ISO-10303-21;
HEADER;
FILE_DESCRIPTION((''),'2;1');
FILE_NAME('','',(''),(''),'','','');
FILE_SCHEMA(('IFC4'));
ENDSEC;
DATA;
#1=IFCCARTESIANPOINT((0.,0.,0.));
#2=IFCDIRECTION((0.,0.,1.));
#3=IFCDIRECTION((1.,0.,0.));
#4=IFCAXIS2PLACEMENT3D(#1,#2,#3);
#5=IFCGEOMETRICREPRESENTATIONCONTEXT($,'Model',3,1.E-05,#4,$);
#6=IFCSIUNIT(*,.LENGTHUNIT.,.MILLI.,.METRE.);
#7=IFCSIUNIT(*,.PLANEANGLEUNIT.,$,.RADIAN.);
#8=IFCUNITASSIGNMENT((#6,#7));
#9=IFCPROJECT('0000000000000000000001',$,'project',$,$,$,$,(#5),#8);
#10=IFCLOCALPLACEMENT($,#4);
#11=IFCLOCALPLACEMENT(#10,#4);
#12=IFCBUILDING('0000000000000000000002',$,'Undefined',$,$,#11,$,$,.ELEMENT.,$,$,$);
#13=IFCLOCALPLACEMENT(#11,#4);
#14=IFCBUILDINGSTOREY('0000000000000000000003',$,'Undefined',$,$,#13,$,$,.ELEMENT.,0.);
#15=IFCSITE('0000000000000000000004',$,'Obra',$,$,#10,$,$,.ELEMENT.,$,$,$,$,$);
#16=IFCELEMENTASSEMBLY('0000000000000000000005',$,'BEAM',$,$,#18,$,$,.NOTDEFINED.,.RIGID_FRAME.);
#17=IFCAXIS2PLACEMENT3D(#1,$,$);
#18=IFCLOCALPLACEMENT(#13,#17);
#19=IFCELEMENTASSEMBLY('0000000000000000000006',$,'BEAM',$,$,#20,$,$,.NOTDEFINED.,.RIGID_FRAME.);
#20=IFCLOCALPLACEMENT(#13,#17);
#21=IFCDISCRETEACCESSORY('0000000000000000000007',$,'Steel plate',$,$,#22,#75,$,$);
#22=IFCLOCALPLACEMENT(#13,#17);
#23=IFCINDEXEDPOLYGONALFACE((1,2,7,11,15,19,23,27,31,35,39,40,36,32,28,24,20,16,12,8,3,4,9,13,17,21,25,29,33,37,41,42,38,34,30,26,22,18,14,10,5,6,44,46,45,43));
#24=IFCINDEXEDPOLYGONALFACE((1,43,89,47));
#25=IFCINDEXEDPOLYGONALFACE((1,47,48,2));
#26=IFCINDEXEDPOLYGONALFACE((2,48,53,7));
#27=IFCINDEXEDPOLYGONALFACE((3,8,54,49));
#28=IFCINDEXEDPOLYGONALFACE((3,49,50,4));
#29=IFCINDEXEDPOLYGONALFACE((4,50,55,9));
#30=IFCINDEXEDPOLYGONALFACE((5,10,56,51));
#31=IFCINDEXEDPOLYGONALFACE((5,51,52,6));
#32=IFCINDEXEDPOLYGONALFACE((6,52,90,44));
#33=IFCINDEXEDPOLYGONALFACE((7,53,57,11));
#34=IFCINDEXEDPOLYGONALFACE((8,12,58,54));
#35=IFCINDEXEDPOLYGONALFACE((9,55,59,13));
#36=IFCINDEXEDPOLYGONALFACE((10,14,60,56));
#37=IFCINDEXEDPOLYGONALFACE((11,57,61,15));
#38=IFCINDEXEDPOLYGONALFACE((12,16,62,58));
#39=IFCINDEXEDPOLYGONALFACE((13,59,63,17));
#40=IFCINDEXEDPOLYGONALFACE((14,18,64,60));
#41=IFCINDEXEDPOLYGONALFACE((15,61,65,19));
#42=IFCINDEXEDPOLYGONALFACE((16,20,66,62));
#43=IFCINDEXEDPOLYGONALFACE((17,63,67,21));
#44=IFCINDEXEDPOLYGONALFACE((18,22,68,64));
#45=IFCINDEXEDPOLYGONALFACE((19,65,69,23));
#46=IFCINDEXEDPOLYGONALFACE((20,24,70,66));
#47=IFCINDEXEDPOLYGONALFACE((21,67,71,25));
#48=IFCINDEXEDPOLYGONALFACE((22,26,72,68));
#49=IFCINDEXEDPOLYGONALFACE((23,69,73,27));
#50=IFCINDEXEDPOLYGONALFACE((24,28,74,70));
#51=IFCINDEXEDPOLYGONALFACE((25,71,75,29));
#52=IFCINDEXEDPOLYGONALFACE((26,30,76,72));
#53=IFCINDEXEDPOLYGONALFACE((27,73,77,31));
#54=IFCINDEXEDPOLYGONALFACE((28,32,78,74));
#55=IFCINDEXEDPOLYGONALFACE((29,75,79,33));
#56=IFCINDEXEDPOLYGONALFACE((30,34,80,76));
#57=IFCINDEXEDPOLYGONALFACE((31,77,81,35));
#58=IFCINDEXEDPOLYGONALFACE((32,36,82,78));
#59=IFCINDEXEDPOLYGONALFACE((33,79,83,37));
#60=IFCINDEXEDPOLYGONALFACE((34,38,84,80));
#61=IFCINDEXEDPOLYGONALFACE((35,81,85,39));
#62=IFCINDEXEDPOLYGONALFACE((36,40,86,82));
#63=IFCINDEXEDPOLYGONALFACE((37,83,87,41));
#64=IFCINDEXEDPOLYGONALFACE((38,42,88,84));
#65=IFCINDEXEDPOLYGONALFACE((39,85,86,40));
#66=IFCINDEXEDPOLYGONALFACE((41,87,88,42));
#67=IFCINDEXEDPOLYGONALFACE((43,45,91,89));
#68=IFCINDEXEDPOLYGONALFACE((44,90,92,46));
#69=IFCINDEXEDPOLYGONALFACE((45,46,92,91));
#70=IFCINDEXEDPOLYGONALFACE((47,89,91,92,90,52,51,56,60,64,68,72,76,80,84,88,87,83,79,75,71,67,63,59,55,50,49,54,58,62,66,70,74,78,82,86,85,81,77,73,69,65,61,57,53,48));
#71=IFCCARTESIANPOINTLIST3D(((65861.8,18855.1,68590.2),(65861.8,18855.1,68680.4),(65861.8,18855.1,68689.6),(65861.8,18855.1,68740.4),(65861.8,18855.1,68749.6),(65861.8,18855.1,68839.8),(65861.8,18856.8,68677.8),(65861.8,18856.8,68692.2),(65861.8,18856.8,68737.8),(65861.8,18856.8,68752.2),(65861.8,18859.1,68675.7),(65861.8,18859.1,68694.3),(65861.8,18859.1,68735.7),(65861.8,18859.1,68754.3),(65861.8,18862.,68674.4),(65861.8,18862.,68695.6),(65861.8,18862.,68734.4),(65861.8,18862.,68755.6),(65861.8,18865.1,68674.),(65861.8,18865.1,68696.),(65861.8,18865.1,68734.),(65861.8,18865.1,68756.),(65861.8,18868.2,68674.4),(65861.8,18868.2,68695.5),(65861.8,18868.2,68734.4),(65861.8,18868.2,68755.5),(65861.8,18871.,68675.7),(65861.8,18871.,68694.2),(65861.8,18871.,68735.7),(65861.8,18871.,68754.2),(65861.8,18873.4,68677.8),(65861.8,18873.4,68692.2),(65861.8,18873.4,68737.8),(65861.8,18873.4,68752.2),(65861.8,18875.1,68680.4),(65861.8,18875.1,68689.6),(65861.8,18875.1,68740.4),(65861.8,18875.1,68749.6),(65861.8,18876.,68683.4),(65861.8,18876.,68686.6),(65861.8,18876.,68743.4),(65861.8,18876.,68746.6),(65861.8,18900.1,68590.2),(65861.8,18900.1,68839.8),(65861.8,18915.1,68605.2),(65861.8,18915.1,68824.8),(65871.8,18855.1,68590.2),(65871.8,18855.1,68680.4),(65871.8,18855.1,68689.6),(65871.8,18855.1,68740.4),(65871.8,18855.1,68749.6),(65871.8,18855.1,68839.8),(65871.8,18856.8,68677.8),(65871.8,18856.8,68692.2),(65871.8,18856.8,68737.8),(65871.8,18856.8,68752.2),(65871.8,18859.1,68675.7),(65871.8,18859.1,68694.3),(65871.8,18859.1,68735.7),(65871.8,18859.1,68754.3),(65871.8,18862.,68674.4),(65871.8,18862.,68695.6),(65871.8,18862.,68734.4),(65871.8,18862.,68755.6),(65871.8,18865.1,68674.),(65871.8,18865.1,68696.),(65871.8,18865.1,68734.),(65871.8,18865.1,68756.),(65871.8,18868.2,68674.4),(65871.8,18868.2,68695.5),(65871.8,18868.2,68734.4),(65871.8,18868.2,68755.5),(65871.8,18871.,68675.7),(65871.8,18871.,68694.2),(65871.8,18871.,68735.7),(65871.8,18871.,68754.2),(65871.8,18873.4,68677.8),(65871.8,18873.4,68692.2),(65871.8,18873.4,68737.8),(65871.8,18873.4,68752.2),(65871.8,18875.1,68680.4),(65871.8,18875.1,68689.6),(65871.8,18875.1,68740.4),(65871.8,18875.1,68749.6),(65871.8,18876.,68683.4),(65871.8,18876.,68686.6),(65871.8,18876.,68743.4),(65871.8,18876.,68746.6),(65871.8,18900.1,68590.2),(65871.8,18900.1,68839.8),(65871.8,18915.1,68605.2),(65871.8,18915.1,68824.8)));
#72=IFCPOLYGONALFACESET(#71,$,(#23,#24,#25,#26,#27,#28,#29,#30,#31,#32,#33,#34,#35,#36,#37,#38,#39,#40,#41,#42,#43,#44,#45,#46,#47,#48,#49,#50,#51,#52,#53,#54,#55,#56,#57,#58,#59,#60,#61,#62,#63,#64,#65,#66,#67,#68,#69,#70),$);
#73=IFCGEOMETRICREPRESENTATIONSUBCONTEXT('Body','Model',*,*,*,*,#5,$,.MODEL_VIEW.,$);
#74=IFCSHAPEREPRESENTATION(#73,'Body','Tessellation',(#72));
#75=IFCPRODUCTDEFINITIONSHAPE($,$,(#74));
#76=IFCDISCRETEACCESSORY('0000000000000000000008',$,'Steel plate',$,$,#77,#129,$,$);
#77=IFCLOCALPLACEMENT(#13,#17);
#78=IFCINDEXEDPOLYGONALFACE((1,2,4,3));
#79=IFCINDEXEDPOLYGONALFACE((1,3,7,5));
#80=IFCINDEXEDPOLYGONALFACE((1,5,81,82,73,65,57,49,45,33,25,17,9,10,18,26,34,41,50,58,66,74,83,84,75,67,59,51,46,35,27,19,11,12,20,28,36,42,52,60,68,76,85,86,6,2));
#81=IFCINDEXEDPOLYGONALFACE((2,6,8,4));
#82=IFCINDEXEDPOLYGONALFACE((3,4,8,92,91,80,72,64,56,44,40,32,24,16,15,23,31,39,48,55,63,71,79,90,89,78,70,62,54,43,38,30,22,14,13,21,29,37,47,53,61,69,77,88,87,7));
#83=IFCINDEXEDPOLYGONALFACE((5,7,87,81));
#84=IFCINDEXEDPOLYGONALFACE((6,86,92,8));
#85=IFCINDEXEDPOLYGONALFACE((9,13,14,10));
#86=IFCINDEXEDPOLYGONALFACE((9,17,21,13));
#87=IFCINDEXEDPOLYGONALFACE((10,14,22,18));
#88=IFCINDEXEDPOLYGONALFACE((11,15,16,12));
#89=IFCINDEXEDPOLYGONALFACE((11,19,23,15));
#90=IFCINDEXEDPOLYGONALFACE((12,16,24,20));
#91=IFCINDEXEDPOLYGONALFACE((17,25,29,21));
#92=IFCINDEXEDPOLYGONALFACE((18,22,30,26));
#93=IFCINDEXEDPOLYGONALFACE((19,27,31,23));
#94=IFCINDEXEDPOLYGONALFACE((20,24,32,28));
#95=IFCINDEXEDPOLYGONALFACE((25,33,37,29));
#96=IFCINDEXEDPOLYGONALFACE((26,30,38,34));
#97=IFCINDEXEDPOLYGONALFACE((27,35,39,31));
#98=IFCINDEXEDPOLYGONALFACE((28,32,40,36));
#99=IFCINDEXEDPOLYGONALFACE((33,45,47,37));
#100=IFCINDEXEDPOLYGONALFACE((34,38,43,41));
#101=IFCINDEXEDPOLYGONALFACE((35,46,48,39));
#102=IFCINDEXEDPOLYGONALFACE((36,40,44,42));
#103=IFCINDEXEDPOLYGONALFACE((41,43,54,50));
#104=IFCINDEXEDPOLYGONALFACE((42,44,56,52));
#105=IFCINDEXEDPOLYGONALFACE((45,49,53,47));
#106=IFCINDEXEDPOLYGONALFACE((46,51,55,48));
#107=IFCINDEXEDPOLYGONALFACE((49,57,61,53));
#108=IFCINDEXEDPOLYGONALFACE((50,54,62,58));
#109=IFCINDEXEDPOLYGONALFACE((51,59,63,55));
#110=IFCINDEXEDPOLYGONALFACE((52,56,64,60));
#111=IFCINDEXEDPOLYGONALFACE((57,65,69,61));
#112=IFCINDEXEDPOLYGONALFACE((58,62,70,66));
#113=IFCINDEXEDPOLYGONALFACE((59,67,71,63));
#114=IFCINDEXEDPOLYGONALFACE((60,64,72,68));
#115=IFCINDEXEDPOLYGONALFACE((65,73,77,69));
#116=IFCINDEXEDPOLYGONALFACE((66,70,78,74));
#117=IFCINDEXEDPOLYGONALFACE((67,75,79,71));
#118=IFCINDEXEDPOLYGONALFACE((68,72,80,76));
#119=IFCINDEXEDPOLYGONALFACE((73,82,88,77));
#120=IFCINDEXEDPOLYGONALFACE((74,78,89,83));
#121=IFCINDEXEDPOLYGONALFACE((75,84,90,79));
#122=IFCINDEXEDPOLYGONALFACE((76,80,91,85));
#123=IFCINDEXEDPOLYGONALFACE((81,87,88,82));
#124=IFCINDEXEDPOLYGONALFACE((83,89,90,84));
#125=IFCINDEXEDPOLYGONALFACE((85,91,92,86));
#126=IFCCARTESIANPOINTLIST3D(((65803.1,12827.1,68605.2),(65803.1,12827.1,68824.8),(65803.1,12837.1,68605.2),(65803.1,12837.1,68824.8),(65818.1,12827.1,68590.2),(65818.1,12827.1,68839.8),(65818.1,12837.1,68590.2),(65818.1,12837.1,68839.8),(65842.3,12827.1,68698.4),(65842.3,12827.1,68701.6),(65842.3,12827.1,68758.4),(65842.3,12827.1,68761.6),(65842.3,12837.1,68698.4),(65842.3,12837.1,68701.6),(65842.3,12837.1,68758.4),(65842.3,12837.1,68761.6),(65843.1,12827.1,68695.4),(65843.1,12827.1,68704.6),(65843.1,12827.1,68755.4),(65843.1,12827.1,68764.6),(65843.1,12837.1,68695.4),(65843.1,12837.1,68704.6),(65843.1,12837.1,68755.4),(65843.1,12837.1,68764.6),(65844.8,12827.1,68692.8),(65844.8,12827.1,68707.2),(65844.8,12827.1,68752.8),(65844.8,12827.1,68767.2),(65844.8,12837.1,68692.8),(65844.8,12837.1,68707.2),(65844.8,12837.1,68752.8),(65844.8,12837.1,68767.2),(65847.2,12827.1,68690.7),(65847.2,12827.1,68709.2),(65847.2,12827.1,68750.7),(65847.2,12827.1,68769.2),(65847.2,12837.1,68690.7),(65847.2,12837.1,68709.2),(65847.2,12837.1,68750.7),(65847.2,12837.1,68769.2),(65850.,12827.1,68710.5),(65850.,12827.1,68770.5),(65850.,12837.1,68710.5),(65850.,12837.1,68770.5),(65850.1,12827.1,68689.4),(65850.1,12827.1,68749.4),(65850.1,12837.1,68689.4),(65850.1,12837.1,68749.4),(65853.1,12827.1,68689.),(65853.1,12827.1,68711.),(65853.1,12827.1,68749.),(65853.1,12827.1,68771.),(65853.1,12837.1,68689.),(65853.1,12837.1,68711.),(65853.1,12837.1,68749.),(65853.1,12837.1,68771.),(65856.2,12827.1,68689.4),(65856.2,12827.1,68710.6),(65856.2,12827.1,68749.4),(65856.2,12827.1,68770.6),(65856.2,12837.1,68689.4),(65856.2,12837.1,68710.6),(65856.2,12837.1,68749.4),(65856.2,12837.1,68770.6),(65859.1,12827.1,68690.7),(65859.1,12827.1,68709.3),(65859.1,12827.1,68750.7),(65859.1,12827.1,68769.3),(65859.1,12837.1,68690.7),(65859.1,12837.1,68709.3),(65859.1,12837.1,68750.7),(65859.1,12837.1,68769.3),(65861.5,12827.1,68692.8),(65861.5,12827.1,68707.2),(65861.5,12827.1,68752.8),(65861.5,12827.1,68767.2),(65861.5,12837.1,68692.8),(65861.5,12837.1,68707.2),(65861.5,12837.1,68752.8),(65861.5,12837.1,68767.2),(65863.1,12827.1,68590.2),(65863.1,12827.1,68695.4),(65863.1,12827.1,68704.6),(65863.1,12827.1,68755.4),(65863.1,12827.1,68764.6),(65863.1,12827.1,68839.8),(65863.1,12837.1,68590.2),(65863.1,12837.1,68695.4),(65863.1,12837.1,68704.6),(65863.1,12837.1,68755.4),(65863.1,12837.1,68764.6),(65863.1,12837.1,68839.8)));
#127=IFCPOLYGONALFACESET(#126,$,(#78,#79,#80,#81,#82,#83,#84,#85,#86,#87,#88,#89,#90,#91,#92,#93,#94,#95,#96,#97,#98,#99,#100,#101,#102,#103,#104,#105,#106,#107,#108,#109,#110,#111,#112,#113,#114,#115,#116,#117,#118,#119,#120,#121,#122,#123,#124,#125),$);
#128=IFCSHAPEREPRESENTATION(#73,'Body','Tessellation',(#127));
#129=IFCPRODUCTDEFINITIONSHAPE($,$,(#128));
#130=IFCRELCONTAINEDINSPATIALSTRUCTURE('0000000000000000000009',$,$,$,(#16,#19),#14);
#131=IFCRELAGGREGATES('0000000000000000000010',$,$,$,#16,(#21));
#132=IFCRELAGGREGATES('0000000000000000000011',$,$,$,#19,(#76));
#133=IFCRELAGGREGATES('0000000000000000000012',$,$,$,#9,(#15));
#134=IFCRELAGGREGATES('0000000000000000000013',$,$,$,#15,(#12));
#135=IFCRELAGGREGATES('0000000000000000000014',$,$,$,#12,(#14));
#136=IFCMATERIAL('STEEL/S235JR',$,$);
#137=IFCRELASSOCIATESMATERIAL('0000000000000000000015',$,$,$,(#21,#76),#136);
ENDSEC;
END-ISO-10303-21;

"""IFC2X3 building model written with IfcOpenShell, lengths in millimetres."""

from ifc_helpers import new_model, si_unit, frame, origin_with_axes, origin_2d_with_axis, place, context, subcontext, project, spatial, polyline, circle, outline, extrude, source, transform, mapped, material, element, aggregate, save


model = new_model("IFC2X3")

# Units and contexts
model_context = context("Model", 3, precision=1e-05, world=origin_with_axes())
body_context = subcontext(model_context, "Body", "Model", "MODEL_VIEW")
ifc_project = project(units=[si_unit("LENGTHUNIT", "METRE", prefix="MILLI"), si_unit("PLANEANGLEUNIT", "RADIAN")], contexts=[model_context])

# Site, building, storey
site_placement = place(None, origin_with_axes())
site = spatial("IfcSite", under=ifc_project, at=site_placement, Name="Obra", CompositionType="ELEMENT")
building_placement = place(site_placement, origin_with_axes())
building = spatial("IfcBuilding", under=site, at=building_placement, Name="Undefined", CompositionType="ELEMENT")
storey_placement = place(building_placement, origin_with_axes())
storey = spatial("IfcBuildingStorey", under=building, at=storey_placement, Name="Undefined", CompositionType="ELEMENT", Elevation=0.0)

# Shared definitions
ifc_material = material(Name="STEEL/S235JR")

# Element assembly
assembly_1_placement = place(storey_placement, origin_with_axes())
assembly_1 = element("IfcElementAssembly", 1, at=assembly_1_placement, inside=storey, Name="BEAM", AssemblyPlace="NOTDEFINED", PredefinedType="RIGID_FRAME")

# Element assembly
assembly_2_placement = place(storey_placement, origin_with_axes())
assembly_2 = element("IfcElementAssembly", 2, at=assembly_2_placement, inside=storey, Name="BEAM", AssemblyPlace="NOTDEFINED", PredefinedType="RIGID_FRAME")

# Discrete accessories, openings
discrete_accessory_1_placement = place(assembly_1_placement, frame((65866.8, 18855.1, 68590.2), z_axis=(1.0, 0.000001, 0.0), x_axis=(-0.000002, 1.0, 0.0)))
discrete_accessory_1 = element("IfcDiscreteAccessory", 3, at=discrete_accessory_1_placement, material=ifc_material, Name="Steel plate", context=body_context, shape_type="SweptSolid", body=[
    extrude(outline(polyline([(0.0, 0.0), (45.0, 0.0), (60.0, 15.0), (60.0, 234.6), (45.0, 249.6), (0.0, 249.6), (0.0, 0.0)])), frame((0.0, 0.0, -5.0), z_axis=(0.0, 0.0, 1.0), x_axis=(1.0, 0.0, 0.0)), (0.0, 0.0, 1.0), 10.0),
])
shared_shape_1 = source(origin_with_axes(), body_context, "Body", "SweptSolid", [
    extrude(circle(Radius=11.0, at=origin_2d_with_axis()), frame((0.0, -13.4, 0.0), z_axis=(0.0, 1.0, 0.0), x_axis=(1.0, 0.0, 0.0)), (0.0, 0.0, 1.0), 10.2),
])
opening_1_placement = place(assembly_1_placement, frame((65875.1, 18905.1, 68850.0), z_axis=(0.000002, -1.0, 0.0), x_axis=(0.0, 0.0, -1.0)))
element("IfcOpeningElement", 4, at=opening_1_placement, cuts=discrete_accessory_1, ObjectType="Opening", context=body_context, shape_type="MappedRepresentation", body=[
    mapped(shared_shape_1, transform((105.0, 0.0, 40.0))),
    mapped(shared_shape_1, transform((165.0, 0.0, 40.0))),
])
aggregate(assembly_1, [discrete_accessory_1])
discrete_accessory_2_placement = place(assembly_2_placement, frame((65863.1, 12832.1, 68590.2), z_axis=(0.0, 1.0, 0.0), x_axis=(-1.0, 0.0, 0.0)))
discrete_accessory_2 = element("IfcDiscreteAccessory", 5, at=discrete_accessory_2_placement, material=ifc_material, Name="Steel plate", context=body_context, shape_type="SweptSolid", body=[
    extrude(outline(polyline([(0.0, 0.0), (45.0, 0.0), (60.0, 15.0), (60.0, 234.6), (45.0, 249.6), (0.0, 249.6), (0.0, 0.0)])), frame((0.0, 0.0, -5.0), z_axis=(0.0, 0.0, 1.0), x_axis=(1.0, 0.0, 0.0)), (0.0, 0.0, 1.0), 10.0),
])
shared_shape_2 = source(origin_with_axes(), body_context, "Body", "SweptSolid", [
    extrude(circle(Radius=11.0, at=origin_2d_with_axis()), frame((0.0, -13.2, 0.0), z_axis=(0.0, 1.0, 0.0), x_axis=(1.0, 0.0, 0.0)), (0.0, 0.0, 1.0), 10.2),
])
opening_2_placement = place(assembly_2_placement, frame((65813.1, 12840.2, 68850.0), z_axis=(1.0, 0.0, 0.0), x_axis=(0.0, 0.0, -1.0)))
element("IfcOpeningElement", 6, at=opening_2_placement, cuts=discrete_accessory_2, ObjectType="Opening", context=body_context, shape_type="MappedRepresentation", body=[
    mapped(shared_shape_2, transform((90.0, 0.0, 40.0))),
    mapped(shared_shape_2, transform((150.0, 0.0, 40.0))),
])
aggregate(assembly_2, [discrete_accessory_2])

save(model, "model.ifc")
